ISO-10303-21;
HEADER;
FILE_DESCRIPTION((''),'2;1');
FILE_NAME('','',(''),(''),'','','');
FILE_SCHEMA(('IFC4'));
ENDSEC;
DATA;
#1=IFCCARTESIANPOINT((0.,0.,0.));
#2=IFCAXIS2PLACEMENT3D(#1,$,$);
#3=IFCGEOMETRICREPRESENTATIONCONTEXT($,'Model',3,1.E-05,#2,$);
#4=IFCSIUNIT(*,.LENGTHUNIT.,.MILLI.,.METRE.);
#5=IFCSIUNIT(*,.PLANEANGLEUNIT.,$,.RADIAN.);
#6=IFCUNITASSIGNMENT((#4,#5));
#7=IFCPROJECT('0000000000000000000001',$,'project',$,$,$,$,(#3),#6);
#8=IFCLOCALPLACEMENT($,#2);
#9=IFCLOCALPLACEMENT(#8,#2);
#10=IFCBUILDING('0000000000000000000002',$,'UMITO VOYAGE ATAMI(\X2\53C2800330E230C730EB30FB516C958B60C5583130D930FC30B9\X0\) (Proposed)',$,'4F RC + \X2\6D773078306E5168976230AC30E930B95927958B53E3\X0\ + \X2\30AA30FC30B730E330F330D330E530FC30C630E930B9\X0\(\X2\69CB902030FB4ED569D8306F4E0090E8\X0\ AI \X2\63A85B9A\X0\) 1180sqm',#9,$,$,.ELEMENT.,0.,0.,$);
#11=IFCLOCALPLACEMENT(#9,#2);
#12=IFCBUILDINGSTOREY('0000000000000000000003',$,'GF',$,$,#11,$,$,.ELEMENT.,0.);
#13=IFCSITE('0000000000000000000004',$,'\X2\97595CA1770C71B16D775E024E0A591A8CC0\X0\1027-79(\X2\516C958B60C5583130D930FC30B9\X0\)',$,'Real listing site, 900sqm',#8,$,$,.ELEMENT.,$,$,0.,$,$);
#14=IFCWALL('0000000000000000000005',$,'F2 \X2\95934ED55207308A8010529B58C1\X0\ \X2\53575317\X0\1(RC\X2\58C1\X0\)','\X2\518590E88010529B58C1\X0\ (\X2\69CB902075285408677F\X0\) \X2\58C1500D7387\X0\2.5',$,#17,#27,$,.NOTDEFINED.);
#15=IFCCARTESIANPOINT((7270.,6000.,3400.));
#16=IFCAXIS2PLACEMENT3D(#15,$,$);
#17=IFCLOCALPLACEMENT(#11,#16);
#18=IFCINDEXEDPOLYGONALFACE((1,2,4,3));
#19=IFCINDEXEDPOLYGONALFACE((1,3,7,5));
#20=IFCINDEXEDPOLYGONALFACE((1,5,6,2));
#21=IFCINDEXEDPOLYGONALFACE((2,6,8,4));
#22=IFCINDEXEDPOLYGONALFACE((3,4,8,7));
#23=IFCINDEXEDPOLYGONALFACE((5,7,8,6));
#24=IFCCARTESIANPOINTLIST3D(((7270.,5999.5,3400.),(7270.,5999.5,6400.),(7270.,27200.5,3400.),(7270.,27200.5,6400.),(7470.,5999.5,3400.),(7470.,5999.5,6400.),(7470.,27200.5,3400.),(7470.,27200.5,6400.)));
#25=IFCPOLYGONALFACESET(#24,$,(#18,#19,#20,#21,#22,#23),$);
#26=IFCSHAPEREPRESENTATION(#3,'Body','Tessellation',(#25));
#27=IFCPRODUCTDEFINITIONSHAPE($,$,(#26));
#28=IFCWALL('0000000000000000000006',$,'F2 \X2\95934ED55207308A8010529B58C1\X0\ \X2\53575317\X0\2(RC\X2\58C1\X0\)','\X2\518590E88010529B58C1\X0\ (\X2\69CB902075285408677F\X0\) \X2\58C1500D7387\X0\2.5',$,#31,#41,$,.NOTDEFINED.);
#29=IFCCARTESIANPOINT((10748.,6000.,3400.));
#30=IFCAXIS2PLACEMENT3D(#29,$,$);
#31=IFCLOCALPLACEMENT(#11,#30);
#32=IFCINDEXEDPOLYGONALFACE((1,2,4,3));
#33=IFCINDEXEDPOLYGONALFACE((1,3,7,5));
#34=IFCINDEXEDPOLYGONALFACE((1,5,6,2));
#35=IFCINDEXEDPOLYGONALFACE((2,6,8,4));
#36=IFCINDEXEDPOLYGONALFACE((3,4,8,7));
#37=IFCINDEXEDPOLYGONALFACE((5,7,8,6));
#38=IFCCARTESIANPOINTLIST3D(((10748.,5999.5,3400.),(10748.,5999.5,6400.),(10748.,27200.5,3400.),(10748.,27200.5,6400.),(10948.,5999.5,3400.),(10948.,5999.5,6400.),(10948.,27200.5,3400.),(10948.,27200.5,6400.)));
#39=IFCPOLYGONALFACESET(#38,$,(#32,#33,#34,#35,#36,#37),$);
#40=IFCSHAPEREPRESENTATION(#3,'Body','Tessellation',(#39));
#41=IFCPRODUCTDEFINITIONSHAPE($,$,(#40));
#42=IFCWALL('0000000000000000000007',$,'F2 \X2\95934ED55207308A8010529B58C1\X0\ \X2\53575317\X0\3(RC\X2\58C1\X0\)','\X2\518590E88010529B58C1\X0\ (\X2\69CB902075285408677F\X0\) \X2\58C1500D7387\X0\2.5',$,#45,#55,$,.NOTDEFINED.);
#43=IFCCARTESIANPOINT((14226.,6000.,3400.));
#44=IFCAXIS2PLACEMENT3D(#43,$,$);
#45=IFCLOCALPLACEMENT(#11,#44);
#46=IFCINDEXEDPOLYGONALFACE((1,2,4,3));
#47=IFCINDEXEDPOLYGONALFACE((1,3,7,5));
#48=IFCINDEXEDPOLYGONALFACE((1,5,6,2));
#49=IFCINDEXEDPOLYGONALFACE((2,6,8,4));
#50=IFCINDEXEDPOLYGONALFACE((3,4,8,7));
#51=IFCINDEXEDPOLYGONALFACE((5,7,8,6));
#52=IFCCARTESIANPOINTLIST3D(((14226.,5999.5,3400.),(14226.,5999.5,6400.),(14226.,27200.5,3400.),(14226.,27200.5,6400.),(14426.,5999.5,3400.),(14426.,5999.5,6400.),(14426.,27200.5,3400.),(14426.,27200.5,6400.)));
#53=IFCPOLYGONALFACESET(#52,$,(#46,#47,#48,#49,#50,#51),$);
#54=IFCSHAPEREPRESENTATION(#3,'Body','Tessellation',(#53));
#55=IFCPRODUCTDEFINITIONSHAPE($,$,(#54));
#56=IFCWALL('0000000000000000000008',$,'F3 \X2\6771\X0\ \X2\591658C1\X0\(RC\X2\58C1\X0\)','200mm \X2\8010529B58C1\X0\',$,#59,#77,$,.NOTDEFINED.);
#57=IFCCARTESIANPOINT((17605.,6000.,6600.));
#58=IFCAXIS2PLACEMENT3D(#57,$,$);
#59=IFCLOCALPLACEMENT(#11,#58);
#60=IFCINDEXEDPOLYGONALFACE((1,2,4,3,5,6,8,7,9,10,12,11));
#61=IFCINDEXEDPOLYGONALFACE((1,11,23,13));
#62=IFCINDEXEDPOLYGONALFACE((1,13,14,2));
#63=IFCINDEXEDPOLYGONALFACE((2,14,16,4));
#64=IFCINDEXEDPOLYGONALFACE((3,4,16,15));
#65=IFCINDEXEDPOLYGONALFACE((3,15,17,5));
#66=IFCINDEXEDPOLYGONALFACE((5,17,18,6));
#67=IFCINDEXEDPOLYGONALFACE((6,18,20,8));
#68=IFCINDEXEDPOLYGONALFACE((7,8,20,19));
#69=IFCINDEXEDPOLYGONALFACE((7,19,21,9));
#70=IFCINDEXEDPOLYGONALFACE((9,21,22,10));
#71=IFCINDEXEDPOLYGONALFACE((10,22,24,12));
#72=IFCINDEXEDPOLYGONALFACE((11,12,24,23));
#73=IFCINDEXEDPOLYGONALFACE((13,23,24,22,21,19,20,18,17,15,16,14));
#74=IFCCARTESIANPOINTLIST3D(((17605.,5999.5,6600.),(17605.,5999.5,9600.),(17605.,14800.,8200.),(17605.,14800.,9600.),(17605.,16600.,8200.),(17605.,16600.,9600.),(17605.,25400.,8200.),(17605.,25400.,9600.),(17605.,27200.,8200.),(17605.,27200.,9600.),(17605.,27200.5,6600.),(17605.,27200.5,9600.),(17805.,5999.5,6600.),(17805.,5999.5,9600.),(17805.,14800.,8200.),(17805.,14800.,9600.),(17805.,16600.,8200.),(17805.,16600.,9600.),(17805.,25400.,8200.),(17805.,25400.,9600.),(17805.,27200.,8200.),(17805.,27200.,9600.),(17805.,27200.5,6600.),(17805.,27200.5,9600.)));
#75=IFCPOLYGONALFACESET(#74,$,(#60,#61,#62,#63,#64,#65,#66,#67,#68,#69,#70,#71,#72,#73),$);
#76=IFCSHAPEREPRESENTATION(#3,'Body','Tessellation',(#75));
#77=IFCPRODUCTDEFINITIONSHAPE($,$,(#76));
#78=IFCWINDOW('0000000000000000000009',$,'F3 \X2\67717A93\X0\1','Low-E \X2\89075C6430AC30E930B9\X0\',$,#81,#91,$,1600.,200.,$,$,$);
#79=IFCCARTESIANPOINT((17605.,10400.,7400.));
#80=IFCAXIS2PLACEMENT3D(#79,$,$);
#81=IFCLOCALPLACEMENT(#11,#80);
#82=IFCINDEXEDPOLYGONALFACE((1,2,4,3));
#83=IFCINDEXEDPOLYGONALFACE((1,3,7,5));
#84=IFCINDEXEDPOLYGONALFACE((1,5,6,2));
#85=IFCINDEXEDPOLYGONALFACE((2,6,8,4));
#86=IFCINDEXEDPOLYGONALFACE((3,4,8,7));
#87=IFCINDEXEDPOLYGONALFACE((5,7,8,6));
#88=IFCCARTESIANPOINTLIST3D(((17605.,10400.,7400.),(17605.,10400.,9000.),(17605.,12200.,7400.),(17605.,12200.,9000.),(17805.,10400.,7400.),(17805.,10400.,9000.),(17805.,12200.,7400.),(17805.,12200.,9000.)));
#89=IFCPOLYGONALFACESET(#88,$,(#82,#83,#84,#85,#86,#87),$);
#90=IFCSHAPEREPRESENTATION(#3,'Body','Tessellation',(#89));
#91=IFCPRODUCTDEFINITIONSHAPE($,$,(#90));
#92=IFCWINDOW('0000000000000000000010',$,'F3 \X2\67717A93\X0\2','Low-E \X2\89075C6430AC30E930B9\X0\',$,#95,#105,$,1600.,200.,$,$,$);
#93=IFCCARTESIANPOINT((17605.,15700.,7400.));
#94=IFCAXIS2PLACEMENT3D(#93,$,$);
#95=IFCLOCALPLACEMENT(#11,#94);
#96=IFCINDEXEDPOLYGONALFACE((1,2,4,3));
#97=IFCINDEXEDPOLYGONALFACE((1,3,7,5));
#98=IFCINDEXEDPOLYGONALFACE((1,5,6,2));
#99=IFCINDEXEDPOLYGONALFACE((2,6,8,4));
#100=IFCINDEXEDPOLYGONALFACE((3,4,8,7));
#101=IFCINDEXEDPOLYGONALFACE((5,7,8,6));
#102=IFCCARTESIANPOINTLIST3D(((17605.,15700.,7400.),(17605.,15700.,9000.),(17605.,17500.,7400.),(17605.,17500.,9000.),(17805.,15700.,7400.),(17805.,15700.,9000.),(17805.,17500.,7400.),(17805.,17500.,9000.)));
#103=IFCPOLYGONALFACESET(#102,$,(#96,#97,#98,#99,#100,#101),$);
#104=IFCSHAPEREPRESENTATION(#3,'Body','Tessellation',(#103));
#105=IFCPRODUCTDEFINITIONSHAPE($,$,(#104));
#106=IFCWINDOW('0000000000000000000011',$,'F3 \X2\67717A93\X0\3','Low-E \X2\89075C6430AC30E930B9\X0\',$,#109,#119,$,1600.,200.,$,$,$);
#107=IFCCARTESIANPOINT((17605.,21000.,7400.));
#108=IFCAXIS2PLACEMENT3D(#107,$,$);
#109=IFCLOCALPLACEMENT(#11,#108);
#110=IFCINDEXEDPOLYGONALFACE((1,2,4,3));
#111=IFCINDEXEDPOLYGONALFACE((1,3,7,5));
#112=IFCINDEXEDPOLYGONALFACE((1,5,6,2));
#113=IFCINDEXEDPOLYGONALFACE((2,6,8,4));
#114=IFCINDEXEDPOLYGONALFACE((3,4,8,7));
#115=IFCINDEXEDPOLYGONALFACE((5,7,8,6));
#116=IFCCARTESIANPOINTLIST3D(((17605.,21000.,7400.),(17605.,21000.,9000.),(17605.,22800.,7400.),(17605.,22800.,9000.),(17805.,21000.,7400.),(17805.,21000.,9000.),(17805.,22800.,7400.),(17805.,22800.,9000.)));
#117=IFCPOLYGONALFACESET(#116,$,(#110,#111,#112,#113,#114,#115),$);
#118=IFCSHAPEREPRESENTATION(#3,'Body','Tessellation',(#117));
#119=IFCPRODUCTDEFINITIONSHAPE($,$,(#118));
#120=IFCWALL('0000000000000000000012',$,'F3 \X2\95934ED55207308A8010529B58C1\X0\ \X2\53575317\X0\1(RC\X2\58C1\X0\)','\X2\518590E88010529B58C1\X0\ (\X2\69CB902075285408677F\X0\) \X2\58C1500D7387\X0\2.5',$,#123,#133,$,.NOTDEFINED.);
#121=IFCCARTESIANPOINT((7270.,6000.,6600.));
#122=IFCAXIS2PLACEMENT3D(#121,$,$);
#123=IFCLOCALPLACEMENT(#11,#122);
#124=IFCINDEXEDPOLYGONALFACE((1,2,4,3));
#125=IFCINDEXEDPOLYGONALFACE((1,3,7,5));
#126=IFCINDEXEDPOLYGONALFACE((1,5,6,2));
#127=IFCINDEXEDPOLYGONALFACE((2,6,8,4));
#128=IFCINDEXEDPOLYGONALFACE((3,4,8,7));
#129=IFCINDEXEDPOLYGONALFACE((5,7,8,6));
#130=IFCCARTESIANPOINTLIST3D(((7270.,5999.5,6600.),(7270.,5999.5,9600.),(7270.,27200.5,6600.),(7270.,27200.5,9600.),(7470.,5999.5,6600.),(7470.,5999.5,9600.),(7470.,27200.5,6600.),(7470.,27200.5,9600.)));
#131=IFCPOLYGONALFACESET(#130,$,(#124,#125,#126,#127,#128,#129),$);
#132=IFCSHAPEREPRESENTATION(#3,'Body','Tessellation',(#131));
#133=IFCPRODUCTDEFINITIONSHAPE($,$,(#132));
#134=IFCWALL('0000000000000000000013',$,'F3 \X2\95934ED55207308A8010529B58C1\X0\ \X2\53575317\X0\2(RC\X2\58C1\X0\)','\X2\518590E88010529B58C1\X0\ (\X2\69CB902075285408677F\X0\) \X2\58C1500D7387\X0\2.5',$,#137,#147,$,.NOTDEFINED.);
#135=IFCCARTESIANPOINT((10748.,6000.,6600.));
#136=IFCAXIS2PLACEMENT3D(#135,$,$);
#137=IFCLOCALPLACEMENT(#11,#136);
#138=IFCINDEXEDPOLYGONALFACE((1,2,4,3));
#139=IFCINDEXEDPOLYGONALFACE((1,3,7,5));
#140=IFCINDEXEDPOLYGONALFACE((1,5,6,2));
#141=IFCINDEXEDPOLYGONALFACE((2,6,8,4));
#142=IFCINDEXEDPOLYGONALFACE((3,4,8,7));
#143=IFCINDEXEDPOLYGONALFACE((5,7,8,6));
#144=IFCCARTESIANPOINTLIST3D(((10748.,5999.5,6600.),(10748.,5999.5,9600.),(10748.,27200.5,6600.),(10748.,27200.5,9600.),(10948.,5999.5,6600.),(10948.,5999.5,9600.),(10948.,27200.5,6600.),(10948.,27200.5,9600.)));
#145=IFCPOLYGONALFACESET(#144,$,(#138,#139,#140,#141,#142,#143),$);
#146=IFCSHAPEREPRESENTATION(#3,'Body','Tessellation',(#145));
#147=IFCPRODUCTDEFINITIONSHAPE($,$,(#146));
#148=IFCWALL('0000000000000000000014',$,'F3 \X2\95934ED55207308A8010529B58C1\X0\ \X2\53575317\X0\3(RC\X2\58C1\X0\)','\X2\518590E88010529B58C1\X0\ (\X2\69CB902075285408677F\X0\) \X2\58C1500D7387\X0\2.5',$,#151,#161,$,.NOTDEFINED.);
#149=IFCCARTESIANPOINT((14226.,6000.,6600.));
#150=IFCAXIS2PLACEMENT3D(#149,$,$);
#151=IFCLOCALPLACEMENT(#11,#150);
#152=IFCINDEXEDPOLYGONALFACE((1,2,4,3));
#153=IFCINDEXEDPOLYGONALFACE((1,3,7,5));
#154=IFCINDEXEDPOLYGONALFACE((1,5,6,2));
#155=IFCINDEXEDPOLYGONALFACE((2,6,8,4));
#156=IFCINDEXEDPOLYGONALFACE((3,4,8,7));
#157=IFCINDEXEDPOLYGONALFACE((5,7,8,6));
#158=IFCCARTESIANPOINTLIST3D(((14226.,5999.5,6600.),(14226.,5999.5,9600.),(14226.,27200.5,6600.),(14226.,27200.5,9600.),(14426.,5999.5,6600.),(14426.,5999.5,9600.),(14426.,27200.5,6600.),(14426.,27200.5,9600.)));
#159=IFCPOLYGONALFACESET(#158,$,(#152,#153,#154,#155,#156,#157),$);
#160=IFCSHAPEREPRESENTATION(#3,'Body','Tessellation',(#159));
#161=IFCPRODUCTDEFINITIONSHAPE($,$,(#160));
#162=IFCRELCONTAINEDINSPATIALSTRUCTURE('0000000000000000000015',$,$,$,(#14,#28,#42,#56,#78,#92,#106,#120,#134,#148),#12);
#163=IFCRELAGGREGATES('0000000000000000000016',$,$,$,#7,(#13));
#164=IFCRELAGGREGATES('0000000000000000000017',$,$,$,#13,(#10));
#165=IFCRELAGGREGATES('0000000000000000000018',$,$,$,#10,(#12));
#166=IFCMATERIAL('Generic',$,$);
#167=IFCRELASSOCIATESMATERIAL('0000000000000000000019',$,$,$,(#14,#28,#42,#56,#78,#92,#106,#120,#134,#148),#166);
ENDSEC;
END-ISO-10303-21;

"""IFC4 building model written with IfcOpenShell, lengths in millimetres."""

from ifc_helpers import new_model, si_unit, frame, frame_2d, origin, place, context, project, spatial, rectangle, extrude, material, element, fill, save


model = new_model("IFC4")

# Units and contexts
model_context = context("Model", 3, precision=1e-05, world=origin())
ifc_project = project(units=[si_unit("LENGTHUNIT", "METRE", prefix="MILLI"), si_unit("PLANEANGLEUNIT", "RADIAN")], contexts=[model_context])

# Site, building, storey
site_placement = place(None, origin())
site = spatial("IfcSite", under=ifc_project, at=site_placement, Name="静岡県熱海市上多賀1027-79(公開情報ベース)", ObjectType="Real listing site, 900sqm", CompositionType="ELEMENT", RefElevation=0.0)
building_placement = place(site_placement, origin())
building = spatial("IfcBuilding", under=site, at=building_placement, Name="UMITO VOYAGE ATAMI(参考モデル・公開情報ベース) (Proposed)", ObjectType="4F RC + 海への全面ガラス大開口 + オーシャンビューテラス(構造・仕様は一部 AI 推定) 1180sqm", CompositionType="ELEMENT", ElevationOfRefHeight=0.0, ElevationOfTerrain=0.0)
storey_placement = place(building_placement, origin())
storey = spatial("IfcBuildingStorey", under=building, at=storey_placement, Name="GF", CompositionType="ELEMENT", Elevation=0.0)

# Shared definitions
ifc_material = material(Name="Generic")

# Walls
wall_1_placement = place(storey_placement, frame((7270.0, 6000.0, 3400.0)))
element("IfcWall", 1, at=wall_1_placement, inside=storey, material=ifc_material, Name="F2 間仕切り耐力壁 南北1(RC壁)", Description="内部耐力壁 (構造用合板) 壁倍率2.5", PredefinedType="NOTDEFINED", context=model_context, shape_type="SweptSolid", body=[
    extrude(rectangle(XDim=200.0, YDim=21201.0, at=frame_2d((100.0, 10600.0))), frame((7270.0, 6000.0, 3400.0)), (0.0, 0.0, 1.0), 3000.0),
])
wall_2_placement = place(storey_placement, frame((10748.0, 6000.0, 3400.0)))
element("IfcWall", 2, at=wall_2_placement, inside=storey, material=ifc_material, Name="F2 間仕切り耐力壁 南北2(RC壁)", Description="内部耐力壁 (構造用合板) 壁倍率2.5", PredefinedType="NOTDEFINED", context=model_context, shape_type="SweptSolid", body=[
    extrude(rectangle(XDim=200.0, YDim=21201.0, at=frame_2d((100.0, 10600.0))), frame((10748.0, 6000.0, 3400.0)), (0.0, 0.0, 1.0), 3000.0),
])
wall_3_placement = place(storey_placement, frame((14226.0, 6000.0, 3400.0)))
element("IfcWall", 3, at=wall_3_placement, inside=storey, material=ifc_material, Name="F2 間仕切り耐力壁 南北3(RC壁)", Description="内部耐力壁 (構造用合板) 壁倍率2.5", PredefinedType="NOTDEFINED", context=model_context, shape_type="SweptSolid", body=[
    extrude(rectangle(XDim=200.0, YDim=21201.0, at=frame_2d((100.0, 10600.0))), frame((14226.0, 6000.0, 3400.0)), (0.0, 0.0, 1.0), 3000.0),
])

# Wall, openings, windows
wall_4_placement = place(storey_placement, frame((17605.0, 6000.0, 6600.0)))
wall_4 = element("IfcWall", 4, at=wall_4_placement, inside=storey, material=ifc_material, Name="F3 東 外壁(RC壁)", Description="200mm 耐力壁", PredefinedType="NOTDEFINED", context=model_context, shape_type="SweptSolid", body=[
    extrude(rectangle(XDim=200.0, YDim=21201.0, at=frame_2d((100.0, 10600.0))), frame((17605.0, 6000.0, 6600.0)), (0.0, 0.0, 1.0), 3000.0),
])
opening_1_placement = place(storey_placement, frame((17605.0, 10400.0, 7400.0)))
opening_1 = element("IfcOpeningElement", 5, at=opening_1_placement, cuts=wall_4, PredefinedType="NOTDEFINED", context=model_context, shape_type="SweptSolid", body=[
    extrude(rectangle(XDim=200.0, YDim=1800.0, at=frame_2d((100.0, 900.0))), frame((17605.0, 10400.0, 7400.0)), (0.0, 0.0, 1.0), 1600.0),
])
opening_2_placement = place(storey_placement, frame((17605.0, 15700.0, 7400.0)))
opening_2 = element("IfcOpeningElement", 6, at=opening_2_placement, cuts=wall_4, PredefinedType="NOTDEFINED", context=model_context, shape_type="SweptSolid", body=[
    extrude(rectangle(XDim=200.0, YDim=1800.0, at=frame_2d((100.0, 900.0))), frame((17605.0, 15700.0, 7400.0)), (0.0, 0.0, 1.0), 1600.0),
])
opening_3_placement = place(storey_placement, frame((17605.0, 21000.0, 7400.0)))
opening_3 = element("IfcOpeningElement", 7, at=opening_3_placement, cuts=wall_4, PredefinedType="NOTDEFINED", context=model_context, shape_type="SweptSolid", body=[
    extrude(rectangle(XDim=200.0, YDim=1800.0, at=frame_2d((100.0, 900.0))), frame((17605.0, 21000.0, 7400.0)), (0.0, 0.0, 1.0), 1600.0),
])
window_1_placement = place(storey_placement, frame((17605.0, 10400.0, 7400.0)))
window_1 = element("IfcWindow", 8, at=window_1_placement, inside=storey, material=ifc_material, Name="F3 東窓1", Description="Low-E 複層ガラス", OverallHeight=1600.0, OverallWidth=200.0, context=model_context, shape_type="SweptSolid", body=[
    extrude(rectangle(XDim=200.0, YDim=1800.0, at=frame_2d((100.0, 900.0))), frame((17605.0, 10400.0, 7400.0)), (0.0, 0.0, 1.0), 1600.0),
])
fill(opening_1, window_1)
window_2_placement = place(storey_placement, frame((17605.0, 15700.0, 7400.0)))
window_2 = element("IfcWindow", 9, at=window_2_placement, inside=storey, material=ifc_material, Name="F3 東窓2", Description="Low-E 複層ガラス", OverallHeight=1600.0, OverallWidth=200.0, context=model_context, shape_type="SweptSolid", body=[
    extrude(rectangle(XDim=200.0, YDim=1800.0, at=frame_2d((100.0, 900.0))), frame((17605.0, 15700.0, 7400.0)), (0.0, 0.0, 1.0), 1600.0),
])
fill(opening_2, window_2)
window_3_placement = place(storey_placement, frame((17605.0, 21000.0, 7400.0)))
window_3 = element("IfcWindow", 10, at=window_3_placement, inside=storey, material=ifc_material, Name="F3 東窓3", Description="Low-E 複層ガラス", OverallHeight=1600.0, OverallWidth=200.0, context=model_context, shape_type="SweptSolid", body=[
    extrude(rectangle(XDim=200.0, YDim=1800.0, at=frame_2d((100.0, 900.0))), frame((17605.0, 21000.0, 7400.0)), (0.0, 0.0, 1.0), 1600.0),
])
fill(opening_3, window_3)

# Walls
wall_5_placement = place(storey_placement, frame((7270.0, 6000.0, 6600.0)))
element("IfcWall", 11, at=wall_5_placement, inside=storey, material=ifc_material, Name="F3 間仕切り耐力壁 南北1(RC壁)", Description="内部耐力壁 (構造用合板) 壁倍率2.5", PredefinedType="NOTDEFINED", context=model_context, shape_type="SweptSolid", body=[
    extrude(rectangle(XDim=200.0, YDim=21201.0, at=frame_2d((100.0, 10600.0))), frame((7270.0, 6000.0, 6600.0)), (0.0, 0.0, 1.0), 3000.0),
])
wall_6_placement = place(storey_placement, frame((10748.0, 6000.0, 6600.0)))
element("IfcWall", 12, at=wall_6_placement, inside=storey, material=ifc_material, Name="F3 間仕切り耐力壁 南北2(RC壁)", Description="内部耐力壁 (構造用合板) 壁倍率2.5", PredefinedType="NOTDEFINED", context=model_context, shape_type="SweptSolid", body=[
    extrude(rectangle(XDim=200.0, YDim=21201.0, at=frame_2d((100.0, 10600.0))), frame((10748.0, 6000.0, 6600.0)), (0.0, 0.0, 1.0), 3000.0),
])
wall_7_placement = place(storey_placement, frame((14226.0, 6000.0, 6600.0)))
element("IfcWall", 13, at=wall_7_placement, inside=storey, material=ifc_material, Name="F3 間仕切り耐力壁 南北3(RC壁)", Description="内部耐力壁 (構造用合板) 壁倍率2.5", PredefinedType="NOTDEFINED", context=model_context, shape_type="SweptSolid", body=[
    extrude(rectangle(XDim=200.0, YDim=21201.0, at=frame_2d((100.0, 10600.0))), frame((14226.0, 6000.0, 6600.0)), (0.0, 0.0, 1.0), 3000.0),
])

save(model, "model.ifc")
